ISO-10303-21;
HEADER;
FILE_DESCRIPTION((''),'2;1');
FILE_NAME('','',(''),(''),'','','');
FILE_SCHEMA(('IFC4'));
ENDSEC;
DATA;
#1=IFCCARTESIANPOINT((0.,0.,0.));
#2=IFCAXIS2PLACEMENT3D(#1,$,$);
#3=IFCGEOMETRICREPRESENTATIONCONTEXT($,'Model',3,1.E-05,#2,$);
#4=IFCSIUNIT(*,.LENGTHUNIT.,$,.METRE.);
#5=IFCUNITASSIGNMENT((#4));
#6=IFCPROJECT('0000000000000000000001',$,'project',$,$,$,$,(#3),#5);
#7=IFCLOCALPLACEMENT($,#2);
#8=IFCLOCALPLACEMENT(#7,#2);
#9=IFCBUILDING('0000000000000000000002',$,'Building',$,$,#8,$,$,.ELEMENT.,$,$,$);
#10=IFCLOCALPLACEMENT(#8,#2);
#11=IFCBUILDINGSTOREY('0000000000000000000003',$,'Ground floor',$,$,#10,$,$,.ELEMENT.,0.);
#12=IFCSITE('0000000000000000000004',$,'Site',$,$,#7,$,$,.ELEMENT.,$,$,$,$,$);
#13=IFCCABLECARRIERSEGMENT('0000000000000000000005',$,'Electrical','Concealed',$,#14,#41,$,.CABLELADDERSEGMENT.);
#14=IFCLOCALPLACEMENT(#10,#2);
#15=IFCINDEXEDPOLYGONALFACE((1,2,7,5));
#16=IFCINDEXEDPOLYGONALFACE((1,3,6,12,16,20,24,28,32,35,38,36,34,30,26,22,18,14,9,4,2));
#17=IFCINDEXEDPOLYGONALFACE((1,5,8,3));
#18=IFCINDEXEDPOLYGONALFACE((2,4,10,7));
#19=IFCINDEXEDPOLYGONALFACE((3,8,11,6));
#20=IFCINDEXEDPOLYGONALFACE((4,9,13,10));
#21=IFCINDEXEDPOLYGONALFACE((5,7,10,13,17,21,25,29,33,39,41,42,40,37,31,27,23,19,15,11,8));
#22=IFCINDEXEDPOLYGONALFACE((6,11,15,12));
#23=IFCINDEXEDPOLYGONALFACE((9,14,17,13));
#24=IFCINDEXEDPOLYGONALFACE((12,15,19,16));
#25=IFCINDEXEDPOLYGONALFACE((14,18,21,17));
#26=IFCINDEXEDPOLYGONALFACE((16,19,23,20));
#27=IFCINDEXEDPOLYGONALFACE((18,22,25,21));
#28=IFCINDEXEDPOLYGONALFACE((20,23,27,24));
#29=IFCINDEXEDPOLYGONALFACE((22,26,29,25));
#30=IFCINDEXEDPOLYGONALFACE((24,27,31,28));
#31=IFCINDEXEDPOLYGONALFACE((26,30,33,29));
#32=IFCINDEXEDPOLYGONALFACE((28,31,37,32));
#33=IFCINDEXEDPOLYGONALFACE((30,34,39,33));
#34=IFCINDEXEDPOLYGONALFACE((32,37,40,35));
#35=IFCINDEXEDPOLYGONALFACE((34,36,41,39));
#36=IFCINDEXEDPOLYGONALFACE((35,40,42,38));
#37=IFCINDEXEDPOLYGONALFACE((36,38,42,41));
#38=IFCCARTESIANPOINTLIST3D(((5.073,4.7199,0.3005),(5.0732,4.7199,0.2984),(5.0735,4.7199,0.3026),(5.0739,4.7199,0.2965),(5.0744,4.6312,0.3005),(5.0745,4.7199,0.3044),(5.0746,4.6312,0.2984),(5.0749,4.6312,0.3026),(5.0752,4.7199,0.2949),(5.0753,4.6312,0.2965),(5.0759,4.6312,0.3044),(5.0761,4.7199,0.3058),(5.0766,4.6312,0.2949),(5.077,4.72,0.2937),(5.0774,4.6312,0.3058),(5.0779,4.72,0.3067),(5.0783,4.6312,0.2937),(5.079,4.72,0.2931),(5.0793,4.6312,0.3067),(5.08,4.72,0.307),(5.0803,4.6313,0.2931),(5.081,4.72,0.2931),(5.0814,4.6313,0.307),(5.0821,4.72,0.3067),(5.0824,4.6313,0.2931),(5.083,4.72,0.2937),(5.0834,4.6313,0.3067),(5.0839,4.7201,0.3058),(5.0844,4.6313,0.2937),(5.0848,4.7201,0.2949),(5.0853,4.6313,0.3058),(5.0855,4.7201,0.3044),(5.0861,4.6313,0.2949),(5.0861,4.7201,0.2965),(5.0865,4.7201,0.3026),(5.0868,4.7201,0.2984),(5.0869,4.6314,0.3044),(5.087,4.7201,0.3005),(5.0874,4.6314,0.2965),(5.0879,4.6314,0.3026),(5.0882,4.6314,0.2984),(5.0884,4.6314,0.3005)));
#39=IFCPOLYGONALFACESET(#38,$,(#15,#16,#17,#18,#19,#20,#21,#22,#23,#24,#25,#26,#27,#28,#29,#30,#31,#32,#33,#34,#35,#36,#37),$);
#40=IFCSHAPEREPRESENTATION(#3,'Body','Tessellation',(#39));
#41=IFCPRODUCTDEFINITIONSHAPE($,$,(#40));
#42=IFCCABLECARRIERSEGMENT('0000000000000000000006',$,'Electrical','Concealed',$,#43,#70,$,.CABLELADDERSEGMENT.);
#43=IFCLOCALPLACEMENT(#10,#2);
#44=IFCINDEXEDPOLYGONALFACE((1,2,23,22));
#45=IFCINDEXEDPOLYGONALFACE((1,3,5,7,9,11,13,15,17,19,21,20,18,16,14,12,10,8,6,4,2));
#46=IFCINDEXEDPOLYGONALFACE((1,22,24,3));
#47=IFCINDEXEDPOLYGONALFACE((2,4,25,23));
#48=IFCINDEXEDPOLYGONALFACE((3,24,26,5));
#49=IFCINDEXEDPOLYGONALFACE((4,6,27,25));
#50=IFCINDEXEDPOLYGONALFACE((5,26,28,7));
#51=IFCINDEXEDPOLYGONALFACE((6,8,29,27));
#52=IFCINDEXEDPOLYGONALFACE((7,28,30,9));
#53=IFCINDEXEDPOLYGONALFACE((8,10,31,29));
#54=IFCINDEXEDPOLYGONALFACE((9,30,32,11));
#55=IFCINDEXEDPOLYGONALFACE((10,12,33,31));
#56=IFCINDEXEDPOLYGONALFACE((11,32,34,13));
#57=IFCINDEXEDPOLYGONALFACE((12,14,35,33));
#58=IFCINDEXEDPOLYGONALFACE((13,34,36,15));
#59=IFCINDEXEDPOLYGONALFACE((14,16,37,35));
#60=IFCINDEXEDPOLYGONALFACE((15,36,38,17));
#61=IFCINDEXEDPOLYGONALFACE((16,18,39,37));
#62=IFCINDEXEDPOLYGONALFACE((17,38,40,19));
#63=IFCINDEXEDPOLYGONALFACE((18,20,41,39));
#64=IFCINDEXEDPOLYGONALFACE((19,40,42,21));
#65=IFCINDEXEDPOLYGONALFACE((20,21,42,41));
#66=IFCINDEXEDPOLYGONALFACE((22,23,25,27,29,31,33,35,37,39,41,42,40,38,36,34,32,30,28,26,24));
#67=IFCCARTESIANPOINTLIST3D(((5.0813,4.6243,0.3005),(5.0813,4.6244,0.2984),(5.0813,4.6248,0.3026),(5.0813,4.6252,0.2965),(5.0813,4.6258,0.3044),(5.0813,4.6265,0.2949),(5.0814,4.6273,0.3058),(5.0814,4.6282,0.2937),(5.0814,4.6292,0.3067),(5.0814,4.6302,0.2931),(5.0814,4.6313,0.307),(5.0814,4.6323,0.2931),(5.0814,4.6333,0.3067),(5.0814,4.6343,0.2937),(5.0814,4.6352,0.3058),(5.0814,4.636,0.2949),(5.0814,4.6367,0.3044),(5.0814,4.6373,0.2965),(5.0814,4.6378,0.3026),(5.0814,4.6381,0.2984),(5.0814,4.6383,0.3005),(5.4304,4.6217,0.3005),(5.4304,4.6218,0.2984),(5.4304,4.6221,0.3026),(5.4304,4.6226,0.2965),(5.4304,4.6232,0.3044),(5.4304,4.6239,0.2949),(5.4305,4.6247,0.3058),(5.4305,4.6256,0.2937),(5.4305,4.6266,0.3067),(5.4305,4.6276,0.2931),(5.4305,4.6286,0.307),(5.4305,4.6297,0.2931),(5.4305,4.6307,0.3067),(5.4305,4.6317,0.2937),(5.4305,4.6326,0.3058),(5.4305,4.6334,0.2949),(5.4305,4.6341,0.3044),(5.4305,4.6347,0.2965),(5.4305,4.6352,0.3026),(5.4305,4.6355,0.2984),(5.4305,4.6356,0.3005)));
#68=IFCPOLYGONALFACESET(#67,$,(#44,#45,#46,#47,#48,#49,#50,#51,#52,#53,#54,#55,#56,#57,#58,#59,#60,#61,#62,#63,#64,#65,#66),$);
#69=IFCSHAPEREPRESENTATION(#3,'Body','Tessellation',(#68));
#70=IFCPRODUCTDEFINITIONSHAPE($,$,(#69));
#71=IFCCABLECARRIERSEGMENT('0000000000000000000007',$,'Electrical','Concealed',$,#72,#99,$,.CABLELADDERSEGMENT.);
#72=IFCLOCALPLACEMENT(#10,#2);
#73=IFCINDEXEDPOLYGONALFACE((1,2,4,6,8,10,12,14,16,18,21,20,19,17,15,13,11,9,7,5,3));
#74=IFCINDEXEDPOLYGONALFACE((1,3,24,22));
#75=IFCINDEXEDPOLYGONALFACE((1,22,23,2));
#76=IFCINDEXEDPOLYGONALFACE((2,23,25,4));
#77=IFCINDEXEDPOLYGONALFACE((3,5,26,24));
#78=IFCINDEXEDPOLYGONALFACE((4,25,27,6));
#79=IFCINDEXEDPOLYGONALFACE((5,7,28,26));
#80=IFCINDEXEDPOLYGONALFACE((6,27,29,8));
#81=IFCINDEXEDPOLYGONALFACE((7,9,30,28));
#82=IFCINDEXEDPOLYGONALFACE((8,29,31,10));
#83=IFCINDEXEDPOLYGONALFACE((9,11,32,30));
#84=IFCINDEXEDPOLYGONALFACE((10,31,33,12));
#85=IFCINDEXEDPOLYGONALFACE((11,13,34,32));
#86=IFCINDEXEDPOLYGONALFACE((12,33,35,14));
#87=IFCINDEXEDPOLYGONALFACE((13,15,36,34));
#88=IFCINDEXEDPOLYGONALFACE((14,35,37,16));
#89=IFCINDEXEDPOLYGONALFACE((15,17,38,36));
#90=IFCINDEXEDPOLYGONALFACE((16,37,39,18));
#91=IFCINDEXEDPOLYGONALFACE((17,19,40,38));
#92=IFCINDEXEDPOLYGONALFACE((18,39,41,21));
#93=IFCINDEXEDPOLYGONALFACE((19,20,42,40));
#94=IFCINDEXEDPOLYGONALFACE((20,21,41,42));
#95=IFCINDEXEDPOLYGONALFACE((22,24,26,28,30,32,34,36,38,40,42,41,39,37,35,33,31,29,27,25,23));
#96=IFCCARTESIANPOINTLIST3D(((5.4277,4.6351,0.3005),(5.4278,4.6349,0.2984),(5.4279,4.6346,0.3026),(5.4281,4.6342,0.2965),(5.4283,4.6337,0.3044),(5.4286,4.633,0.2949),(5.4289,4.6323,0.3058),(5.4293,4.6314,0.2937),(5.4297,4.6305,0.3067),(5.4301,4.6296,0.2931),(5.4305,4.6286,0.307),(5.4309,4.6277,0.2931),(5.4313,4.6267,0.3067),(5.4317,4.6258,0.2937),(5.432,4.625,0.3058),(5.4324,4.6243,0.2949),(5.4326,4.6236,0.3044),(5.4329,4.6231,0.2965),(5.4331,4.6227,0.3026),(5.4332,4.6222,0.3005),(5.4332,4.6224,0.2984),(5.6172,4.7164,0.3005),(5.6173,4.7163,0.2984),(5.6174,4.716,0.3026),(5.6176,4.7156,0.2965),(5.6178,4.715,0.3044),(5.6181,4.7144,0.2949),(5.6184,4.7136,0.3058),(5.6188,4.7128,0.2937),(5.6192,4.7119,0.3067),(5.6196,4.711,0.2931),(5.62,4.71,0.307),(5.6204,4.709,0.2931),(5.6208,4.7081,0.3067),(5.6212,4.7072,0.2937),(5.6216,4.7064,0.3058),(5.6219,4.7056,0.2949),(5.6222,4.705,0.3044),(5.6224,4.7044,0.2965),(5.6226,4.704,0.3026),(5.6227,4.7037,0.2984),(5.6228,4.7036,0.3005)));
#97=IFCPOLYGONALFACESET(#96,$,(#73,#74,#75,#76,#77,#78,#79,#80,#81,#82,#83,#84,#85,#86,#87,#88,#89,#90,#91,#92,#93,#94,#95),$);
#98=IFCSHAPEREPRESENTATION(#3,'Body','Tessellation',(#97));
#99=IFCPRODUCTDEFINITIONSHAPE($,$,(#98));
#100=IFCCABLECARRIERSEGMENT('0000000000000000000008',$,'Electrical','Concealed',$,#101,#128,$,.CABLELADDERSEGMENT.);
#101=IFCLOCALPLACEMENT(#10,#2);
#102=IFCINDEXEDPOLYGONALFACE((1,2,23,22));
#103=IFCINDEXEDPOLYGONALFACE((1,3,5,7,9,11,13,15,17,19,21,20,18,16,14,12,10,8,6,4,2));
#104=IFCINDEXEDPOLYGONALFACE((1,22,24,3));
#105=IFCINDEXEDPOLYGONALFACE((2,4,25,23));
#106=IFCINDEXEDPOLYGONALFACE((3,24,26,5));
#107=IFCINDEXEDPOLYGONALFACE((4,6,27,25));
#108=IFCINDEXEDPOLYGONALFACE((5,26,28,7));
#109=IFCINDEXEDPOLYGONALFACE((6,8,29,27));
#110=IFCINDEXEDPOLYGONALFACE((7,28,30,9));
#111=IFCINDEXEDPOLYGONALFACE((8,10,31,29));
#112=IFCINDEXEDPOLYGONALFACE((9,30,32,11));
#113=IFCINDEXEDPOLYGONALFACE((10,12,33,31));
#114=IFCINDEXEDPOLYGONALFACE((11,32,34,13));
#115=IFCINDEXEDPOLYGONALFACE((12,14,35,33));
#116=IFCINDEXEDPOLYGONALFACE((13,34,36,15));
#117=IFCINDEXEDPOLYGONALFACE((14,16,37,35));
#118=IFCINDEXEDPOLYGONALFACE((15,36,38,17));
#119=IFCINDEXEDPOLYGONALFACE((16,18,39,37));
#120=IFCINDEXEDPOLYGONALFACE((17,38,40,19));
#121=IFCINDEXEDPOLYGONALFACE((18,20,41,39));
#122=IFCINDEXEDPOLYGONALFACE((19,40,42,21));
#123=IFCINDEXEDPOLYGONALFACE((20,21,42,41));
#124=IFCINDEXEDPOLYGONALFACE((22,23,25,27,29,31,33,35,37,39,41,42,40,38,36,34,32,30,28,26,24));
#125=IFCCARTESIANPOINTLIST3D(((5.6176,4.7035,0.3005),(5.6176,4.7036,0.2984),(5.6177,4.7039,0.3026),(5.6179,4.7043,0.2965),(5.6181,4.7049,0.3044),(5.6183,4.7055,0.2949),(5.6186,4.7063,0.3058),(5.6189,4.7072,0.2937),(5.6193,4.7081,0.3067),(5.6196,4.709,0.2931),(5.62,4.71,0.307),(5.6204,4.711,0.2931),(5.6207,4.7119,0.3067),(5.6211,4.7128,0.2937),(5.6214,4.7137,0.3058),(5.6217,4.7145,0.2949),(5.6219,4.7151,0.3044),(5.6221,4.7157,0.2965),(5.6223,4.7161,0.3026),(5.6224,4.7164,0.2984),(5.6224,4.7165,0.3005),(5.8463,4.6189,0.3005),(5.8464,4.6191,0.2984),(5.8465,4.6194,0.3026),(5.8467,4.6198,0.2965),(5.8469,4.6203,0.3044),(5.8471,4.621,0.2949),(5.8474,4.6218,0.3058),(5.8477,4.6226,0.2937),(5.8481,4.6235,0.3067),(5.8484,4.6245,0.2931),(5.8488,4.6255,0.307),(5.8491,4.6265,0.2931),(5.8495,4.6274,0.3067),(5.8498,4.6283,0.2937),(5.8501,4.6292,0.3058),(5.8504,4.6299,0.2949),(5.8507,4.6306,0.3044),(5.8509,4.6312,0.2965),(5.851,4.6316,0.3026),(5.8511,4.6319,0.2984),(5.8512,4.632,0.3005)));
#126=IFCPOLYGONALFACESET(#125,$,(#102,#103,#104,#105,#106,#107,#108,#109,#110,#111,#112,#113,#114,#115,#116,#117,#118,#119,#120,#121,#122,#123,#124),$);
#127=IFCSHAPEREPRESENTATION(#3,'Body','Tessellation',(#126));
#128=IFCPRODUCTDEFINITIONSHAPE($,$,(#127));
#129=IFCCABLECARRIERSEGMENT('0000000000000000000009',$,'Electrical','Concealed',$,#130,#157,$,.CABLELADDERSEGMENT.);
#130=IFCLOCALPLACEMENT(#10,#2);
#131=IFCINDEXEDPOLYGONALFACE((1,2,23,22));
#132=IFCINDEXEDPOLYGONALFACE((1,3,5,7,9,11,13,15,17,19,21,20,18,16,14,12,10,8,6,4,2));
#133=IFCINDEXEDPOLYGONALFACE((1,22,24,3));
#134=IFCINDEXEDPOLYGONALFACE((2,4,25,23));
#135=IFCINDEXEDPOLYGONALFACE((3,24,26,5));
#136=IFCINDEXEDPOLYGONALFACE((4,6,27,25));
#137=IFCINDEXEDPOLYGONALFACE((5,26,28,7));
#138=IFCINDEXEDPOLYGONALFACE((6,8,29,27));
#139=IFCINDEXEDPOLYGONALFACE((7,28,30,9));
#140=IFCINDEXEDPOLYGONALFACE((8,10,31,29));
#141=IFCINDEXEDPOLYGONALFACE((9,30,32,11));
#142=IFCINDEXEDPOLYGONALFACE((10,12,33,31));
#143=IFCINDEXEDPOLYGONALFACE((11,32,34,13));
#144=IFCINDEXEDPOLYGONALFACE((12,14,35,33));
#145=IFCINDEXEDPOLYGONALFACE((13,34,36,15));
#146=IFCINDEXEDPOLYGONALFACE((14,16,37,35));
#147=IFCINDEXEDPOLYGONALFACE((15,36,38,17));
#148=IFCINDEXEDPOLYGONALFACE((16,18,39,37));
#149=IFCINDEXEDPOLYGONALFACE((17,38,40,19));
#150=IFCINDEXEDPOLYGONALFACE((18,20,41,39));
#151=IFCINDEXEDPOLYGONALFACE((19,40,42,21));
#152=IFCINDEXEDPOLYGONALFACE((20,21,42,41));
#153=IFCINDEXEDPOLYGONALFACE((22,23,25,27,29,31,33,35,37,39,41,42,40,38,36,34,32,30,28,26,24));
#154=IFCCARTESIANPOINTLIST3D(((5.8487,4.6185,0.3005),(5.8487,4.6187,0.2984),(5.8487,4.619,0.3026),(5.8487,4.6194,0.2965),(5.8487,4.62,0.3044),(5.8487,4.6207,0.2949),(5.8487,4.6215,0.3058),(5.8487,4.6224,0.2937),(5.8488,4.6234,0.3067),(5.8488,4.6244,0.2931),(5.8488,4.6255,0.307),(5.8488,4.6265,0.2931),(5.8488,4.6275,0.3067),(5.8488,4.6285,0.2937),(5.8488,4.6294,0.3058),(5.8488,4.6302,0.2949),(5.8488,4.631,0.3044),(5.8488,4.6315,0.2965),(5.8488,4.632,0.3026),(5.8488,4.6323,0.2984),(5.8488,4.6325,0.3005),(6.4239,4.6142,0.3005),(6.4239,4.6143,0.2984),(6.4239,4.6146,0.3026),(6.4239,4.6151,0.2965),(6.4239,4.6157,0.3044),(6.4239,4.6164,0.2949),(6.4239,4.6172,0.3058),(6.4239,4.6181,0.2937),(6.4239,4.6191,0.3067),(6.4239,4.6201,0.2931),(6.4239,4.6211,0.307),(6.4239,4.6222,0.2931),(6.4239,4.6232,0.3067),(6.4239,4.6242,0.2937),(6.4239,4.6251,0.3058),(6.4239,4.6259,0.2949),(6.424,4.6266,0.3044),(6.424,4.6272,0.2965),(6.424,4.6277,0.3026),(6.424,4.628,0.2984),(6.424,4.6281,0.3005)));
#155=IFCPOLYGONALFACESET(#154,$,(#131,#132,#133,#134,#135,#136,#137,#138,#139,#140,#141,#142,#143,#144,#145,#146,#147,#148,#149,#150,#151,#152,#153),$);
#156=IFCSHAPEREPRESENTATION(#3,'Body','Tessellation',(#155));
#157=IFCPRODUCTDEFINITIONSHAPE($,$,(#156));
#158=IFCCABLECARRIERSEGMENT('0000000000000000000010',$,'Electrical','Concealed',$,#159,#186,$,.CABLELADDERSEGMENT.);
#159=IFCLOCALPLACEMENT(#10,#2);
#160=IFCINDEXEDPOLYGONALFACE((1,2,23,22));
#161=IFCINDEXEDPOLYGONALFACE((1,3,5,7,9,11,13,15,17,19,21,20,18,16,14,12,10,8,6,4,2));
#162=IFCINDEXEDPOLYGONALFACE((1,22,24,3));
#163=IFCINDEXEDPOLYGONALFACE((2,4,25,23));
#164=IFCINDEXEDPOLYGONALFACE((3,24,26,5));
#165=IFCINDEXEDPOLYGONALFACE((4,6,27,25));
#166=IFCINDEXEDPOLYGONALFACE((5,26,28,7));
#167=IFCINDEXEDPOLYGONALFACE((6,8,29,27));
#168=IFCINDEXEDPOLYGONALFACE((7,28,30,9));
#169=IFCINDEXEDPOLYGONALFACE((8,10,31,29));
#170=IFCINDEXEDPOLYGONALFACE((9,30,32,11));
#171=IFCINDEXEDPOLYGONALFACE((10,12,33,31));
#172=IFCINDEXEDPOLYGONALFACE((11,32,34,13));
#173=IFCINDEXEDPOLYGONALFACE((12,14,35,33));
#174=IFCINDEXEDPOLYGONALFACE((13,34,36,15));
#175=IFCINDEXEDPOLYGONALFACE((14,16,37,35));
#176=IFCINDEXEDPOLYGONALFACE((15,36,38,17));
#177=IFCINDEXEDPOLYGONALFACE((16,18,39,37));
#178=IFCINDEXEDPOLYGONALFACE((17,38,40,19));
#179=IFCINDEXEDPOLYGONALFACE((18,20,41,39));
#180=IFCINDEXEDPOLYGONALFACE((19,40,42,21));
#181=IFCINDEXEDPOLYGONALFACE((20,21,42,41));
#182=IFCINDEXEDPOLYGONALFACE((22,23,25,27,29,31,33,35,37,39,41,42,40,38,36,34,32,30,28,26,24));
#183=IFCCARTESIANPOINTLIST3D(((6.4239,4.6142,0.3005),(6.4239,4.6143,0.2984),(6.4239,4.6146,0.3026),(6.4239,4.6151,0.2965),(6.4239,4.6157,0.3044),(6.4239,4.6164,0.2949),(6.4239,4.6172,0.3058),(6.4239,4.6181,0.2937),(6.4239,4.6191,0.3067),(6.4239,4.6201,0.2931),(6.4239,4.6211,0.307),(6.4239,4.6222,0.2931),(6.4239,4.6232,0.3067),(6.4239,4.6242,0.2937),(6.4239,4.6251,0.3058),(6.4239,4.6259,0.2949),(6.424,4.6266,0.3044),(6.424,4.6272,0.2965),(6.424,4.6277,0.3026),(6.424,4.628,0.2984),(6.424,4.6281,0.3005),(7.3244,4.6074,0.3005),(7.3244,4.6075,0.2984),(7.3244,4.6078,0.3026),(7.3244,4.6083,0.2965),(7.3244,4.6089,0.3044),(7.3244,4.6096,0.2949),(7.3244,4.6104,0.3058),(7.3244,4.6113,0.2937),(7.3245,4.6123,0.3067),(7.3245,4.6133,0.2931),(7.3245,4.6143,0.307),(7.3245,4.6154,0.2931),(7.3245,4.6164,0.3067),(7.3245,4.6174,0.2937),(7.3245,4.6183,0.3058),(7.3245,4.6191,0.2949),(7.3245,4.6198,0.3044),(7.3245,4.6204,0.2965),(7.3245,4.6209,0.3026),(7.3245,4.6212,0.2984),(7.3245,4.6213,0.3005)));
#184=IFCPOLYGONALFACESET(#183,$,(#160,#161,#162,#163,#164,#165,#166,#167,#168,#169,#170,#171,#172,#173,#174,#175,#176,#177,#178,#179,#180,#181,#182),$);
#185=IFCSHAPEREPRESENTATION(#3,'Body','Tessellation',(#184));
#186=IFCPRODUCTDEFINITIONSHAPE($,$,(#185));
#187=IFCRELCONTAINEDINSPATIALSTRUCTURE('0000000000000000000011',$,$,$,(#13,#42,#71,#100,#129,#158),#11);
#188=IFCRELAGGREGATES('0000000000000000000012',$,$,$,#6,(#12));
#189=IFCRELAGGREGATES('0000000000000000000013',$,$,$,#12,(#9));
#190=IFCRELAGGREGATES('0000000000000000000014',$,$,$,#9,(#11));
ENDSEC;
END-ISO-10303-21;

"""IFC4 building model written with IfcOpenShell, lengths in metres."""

from ifc_helpers import new_model, si_unit, frame, origin, origin_2d, place, context, project, spatial, circle, extrude, element, save


model = new_model("IFC4")

# Units and contexts
model_context = context("Model", 3, precision=1e-05, world=origin())
ifc_project = project(units=[si_unit("LENGTHUNIT", "METRE")], contexts=[model_context])

# Site, building, storey
site_placement = place(None, origin())
site = spatial("IfcSite", under=ifc_project, at=site_placement, Name="Site", CompositionType="ELEMENT")
building_placement = place(site_placement, origin())
building = spatial("IfcBuilding", under=site, at=building_placement, Name="Building", CompositionType="ELEMENT")
storey_placement = place(building_placement, origin())
storey = spatial("IfcBuildingStorey", under=building, at=storey_placement, Name="Ground floor", CompositionType="ELEMENT", Elevation=0.0)

# Cable carrier segments
cable_carrier_segment_1_placement = place(storey_placement, frame((5.08, 4.72, 0.3), z_axis=(0.015556, -0.999879, 0.0), x_axis=(0.0, 0.0, 1.0)))
element("IfcCableCarrierSegment", 1, at=cable_carrier_segment_1_placement, inside=storey, Name="Electrical", Description="Concealed", PredefinedType="CABLELADDERSEGMENT", context=model_context, shape_type="SweptSolid", body=[
    extrude(circle(Radius=0.007, at=origin_2d()), origin(), (0.0, 0.0, 1.0), 0.0887),
])
cable_carrier_segment_2_placement = place(storey_placement, frame((5.0814, 4.6313, 0.3), z_axis=(0.999972, -0.007547, 0.0), x_axis=(0.0, 0.0, 1.0)))
element("IfcCableCarrierSegment", 2, at=cable_carrier_segment_2_placement, inside=storey, Name="Electrical", Description="Concealed", PredefinedType="CABLELADDERSEGMENT", context=model_context, shape_type="SweptSolid", body=[
    extrude(circle(Radius=0.007, at=origin_2d()), origin(), (0.0, 0.0, 1.0), 0.3491),
])
cable_carrier_segment_3_placement = place(storey_placement, frame((5.4305, 4.6286, 0.3), z_axis=(0.918897, 0.394498, 0.0), x_axis=(0.0, 0.0, 1.0)))
element("IfcCableCarrierSegment", 3, at=cable_carrier_segment_3_placement, inside=storey, Name="Electrical", Description="Concealed", PredefinedType="CABLELADDERSEGMENT", context=model_context, shape_type="SweptSolid", body=[
    extrude(circle(Radius=0.007, at=origin_2d()), origin(), (0.0, 0.0, 1.0), 0.2062),
])
cable_carrier_segment_4_placement = place(storey_placement, frame((5.62, 4.71, 0.3), z_axis=(0.938028, -0.34656, 0.0), x_axis=(0.0, 0.0, 1.0)))
element("IfcCableCarrierSegment", 4, at=cable_carrier_segment_4_placement, inside=storey, Name="Electrical", Description="Concealed", PredefinedType="CABLELADDERSEGMENT", context=model_context, shape_type="SweptSolid", body=[
    extrude(circle(Radius=0.007, at=origin_2d()), origin(), (0.0, 0.0, 1.0), 0.2439),
])
cable_carrier_segment_5_placement = place(storey_placement, frame((5.8488, 4.6255, 0.3), z_axis=(0.999972, -0.007547, 0.0), x_axis=(0.0, 0.0, 1.0)))
element("IfcCableCarrierSegment", 5, at=cable_carrier_segment_5_placement, inside=storey, Name="Electrical", Description="Concealed", PredefinedType="CABLELADDERSEGMENT", context=model_context, shape_type="SweptSolid", body=[
    extrude(circle(Radius=0.007, at=origin_2d()), origin(), (0.0, 0.0, 1.0), 0.5752),
])
cable_carrier_segment_6_placement = place(storey_placement, frame((6.4239, 4.6211, 0.3), z_axis=(0.999972, -0.007547, 0.0), x_axis=(0.0, 0.0, 1.0)))
element("IfcCableCarrierSegment", 6, at=cable_carrier_segment_6_placement, inside=storey, Name="Electrical", Description="Concealed", PredefinedType="CABLELADDERSEGMENT", context=model_context, shape_type="SweptSolid", body=[
    extrude(circle(Radius=0.007, at=origin_2d()), origin(), (0.0, 0.0, 1.0), 0.9006),
])

save(model, "model.ifc")
